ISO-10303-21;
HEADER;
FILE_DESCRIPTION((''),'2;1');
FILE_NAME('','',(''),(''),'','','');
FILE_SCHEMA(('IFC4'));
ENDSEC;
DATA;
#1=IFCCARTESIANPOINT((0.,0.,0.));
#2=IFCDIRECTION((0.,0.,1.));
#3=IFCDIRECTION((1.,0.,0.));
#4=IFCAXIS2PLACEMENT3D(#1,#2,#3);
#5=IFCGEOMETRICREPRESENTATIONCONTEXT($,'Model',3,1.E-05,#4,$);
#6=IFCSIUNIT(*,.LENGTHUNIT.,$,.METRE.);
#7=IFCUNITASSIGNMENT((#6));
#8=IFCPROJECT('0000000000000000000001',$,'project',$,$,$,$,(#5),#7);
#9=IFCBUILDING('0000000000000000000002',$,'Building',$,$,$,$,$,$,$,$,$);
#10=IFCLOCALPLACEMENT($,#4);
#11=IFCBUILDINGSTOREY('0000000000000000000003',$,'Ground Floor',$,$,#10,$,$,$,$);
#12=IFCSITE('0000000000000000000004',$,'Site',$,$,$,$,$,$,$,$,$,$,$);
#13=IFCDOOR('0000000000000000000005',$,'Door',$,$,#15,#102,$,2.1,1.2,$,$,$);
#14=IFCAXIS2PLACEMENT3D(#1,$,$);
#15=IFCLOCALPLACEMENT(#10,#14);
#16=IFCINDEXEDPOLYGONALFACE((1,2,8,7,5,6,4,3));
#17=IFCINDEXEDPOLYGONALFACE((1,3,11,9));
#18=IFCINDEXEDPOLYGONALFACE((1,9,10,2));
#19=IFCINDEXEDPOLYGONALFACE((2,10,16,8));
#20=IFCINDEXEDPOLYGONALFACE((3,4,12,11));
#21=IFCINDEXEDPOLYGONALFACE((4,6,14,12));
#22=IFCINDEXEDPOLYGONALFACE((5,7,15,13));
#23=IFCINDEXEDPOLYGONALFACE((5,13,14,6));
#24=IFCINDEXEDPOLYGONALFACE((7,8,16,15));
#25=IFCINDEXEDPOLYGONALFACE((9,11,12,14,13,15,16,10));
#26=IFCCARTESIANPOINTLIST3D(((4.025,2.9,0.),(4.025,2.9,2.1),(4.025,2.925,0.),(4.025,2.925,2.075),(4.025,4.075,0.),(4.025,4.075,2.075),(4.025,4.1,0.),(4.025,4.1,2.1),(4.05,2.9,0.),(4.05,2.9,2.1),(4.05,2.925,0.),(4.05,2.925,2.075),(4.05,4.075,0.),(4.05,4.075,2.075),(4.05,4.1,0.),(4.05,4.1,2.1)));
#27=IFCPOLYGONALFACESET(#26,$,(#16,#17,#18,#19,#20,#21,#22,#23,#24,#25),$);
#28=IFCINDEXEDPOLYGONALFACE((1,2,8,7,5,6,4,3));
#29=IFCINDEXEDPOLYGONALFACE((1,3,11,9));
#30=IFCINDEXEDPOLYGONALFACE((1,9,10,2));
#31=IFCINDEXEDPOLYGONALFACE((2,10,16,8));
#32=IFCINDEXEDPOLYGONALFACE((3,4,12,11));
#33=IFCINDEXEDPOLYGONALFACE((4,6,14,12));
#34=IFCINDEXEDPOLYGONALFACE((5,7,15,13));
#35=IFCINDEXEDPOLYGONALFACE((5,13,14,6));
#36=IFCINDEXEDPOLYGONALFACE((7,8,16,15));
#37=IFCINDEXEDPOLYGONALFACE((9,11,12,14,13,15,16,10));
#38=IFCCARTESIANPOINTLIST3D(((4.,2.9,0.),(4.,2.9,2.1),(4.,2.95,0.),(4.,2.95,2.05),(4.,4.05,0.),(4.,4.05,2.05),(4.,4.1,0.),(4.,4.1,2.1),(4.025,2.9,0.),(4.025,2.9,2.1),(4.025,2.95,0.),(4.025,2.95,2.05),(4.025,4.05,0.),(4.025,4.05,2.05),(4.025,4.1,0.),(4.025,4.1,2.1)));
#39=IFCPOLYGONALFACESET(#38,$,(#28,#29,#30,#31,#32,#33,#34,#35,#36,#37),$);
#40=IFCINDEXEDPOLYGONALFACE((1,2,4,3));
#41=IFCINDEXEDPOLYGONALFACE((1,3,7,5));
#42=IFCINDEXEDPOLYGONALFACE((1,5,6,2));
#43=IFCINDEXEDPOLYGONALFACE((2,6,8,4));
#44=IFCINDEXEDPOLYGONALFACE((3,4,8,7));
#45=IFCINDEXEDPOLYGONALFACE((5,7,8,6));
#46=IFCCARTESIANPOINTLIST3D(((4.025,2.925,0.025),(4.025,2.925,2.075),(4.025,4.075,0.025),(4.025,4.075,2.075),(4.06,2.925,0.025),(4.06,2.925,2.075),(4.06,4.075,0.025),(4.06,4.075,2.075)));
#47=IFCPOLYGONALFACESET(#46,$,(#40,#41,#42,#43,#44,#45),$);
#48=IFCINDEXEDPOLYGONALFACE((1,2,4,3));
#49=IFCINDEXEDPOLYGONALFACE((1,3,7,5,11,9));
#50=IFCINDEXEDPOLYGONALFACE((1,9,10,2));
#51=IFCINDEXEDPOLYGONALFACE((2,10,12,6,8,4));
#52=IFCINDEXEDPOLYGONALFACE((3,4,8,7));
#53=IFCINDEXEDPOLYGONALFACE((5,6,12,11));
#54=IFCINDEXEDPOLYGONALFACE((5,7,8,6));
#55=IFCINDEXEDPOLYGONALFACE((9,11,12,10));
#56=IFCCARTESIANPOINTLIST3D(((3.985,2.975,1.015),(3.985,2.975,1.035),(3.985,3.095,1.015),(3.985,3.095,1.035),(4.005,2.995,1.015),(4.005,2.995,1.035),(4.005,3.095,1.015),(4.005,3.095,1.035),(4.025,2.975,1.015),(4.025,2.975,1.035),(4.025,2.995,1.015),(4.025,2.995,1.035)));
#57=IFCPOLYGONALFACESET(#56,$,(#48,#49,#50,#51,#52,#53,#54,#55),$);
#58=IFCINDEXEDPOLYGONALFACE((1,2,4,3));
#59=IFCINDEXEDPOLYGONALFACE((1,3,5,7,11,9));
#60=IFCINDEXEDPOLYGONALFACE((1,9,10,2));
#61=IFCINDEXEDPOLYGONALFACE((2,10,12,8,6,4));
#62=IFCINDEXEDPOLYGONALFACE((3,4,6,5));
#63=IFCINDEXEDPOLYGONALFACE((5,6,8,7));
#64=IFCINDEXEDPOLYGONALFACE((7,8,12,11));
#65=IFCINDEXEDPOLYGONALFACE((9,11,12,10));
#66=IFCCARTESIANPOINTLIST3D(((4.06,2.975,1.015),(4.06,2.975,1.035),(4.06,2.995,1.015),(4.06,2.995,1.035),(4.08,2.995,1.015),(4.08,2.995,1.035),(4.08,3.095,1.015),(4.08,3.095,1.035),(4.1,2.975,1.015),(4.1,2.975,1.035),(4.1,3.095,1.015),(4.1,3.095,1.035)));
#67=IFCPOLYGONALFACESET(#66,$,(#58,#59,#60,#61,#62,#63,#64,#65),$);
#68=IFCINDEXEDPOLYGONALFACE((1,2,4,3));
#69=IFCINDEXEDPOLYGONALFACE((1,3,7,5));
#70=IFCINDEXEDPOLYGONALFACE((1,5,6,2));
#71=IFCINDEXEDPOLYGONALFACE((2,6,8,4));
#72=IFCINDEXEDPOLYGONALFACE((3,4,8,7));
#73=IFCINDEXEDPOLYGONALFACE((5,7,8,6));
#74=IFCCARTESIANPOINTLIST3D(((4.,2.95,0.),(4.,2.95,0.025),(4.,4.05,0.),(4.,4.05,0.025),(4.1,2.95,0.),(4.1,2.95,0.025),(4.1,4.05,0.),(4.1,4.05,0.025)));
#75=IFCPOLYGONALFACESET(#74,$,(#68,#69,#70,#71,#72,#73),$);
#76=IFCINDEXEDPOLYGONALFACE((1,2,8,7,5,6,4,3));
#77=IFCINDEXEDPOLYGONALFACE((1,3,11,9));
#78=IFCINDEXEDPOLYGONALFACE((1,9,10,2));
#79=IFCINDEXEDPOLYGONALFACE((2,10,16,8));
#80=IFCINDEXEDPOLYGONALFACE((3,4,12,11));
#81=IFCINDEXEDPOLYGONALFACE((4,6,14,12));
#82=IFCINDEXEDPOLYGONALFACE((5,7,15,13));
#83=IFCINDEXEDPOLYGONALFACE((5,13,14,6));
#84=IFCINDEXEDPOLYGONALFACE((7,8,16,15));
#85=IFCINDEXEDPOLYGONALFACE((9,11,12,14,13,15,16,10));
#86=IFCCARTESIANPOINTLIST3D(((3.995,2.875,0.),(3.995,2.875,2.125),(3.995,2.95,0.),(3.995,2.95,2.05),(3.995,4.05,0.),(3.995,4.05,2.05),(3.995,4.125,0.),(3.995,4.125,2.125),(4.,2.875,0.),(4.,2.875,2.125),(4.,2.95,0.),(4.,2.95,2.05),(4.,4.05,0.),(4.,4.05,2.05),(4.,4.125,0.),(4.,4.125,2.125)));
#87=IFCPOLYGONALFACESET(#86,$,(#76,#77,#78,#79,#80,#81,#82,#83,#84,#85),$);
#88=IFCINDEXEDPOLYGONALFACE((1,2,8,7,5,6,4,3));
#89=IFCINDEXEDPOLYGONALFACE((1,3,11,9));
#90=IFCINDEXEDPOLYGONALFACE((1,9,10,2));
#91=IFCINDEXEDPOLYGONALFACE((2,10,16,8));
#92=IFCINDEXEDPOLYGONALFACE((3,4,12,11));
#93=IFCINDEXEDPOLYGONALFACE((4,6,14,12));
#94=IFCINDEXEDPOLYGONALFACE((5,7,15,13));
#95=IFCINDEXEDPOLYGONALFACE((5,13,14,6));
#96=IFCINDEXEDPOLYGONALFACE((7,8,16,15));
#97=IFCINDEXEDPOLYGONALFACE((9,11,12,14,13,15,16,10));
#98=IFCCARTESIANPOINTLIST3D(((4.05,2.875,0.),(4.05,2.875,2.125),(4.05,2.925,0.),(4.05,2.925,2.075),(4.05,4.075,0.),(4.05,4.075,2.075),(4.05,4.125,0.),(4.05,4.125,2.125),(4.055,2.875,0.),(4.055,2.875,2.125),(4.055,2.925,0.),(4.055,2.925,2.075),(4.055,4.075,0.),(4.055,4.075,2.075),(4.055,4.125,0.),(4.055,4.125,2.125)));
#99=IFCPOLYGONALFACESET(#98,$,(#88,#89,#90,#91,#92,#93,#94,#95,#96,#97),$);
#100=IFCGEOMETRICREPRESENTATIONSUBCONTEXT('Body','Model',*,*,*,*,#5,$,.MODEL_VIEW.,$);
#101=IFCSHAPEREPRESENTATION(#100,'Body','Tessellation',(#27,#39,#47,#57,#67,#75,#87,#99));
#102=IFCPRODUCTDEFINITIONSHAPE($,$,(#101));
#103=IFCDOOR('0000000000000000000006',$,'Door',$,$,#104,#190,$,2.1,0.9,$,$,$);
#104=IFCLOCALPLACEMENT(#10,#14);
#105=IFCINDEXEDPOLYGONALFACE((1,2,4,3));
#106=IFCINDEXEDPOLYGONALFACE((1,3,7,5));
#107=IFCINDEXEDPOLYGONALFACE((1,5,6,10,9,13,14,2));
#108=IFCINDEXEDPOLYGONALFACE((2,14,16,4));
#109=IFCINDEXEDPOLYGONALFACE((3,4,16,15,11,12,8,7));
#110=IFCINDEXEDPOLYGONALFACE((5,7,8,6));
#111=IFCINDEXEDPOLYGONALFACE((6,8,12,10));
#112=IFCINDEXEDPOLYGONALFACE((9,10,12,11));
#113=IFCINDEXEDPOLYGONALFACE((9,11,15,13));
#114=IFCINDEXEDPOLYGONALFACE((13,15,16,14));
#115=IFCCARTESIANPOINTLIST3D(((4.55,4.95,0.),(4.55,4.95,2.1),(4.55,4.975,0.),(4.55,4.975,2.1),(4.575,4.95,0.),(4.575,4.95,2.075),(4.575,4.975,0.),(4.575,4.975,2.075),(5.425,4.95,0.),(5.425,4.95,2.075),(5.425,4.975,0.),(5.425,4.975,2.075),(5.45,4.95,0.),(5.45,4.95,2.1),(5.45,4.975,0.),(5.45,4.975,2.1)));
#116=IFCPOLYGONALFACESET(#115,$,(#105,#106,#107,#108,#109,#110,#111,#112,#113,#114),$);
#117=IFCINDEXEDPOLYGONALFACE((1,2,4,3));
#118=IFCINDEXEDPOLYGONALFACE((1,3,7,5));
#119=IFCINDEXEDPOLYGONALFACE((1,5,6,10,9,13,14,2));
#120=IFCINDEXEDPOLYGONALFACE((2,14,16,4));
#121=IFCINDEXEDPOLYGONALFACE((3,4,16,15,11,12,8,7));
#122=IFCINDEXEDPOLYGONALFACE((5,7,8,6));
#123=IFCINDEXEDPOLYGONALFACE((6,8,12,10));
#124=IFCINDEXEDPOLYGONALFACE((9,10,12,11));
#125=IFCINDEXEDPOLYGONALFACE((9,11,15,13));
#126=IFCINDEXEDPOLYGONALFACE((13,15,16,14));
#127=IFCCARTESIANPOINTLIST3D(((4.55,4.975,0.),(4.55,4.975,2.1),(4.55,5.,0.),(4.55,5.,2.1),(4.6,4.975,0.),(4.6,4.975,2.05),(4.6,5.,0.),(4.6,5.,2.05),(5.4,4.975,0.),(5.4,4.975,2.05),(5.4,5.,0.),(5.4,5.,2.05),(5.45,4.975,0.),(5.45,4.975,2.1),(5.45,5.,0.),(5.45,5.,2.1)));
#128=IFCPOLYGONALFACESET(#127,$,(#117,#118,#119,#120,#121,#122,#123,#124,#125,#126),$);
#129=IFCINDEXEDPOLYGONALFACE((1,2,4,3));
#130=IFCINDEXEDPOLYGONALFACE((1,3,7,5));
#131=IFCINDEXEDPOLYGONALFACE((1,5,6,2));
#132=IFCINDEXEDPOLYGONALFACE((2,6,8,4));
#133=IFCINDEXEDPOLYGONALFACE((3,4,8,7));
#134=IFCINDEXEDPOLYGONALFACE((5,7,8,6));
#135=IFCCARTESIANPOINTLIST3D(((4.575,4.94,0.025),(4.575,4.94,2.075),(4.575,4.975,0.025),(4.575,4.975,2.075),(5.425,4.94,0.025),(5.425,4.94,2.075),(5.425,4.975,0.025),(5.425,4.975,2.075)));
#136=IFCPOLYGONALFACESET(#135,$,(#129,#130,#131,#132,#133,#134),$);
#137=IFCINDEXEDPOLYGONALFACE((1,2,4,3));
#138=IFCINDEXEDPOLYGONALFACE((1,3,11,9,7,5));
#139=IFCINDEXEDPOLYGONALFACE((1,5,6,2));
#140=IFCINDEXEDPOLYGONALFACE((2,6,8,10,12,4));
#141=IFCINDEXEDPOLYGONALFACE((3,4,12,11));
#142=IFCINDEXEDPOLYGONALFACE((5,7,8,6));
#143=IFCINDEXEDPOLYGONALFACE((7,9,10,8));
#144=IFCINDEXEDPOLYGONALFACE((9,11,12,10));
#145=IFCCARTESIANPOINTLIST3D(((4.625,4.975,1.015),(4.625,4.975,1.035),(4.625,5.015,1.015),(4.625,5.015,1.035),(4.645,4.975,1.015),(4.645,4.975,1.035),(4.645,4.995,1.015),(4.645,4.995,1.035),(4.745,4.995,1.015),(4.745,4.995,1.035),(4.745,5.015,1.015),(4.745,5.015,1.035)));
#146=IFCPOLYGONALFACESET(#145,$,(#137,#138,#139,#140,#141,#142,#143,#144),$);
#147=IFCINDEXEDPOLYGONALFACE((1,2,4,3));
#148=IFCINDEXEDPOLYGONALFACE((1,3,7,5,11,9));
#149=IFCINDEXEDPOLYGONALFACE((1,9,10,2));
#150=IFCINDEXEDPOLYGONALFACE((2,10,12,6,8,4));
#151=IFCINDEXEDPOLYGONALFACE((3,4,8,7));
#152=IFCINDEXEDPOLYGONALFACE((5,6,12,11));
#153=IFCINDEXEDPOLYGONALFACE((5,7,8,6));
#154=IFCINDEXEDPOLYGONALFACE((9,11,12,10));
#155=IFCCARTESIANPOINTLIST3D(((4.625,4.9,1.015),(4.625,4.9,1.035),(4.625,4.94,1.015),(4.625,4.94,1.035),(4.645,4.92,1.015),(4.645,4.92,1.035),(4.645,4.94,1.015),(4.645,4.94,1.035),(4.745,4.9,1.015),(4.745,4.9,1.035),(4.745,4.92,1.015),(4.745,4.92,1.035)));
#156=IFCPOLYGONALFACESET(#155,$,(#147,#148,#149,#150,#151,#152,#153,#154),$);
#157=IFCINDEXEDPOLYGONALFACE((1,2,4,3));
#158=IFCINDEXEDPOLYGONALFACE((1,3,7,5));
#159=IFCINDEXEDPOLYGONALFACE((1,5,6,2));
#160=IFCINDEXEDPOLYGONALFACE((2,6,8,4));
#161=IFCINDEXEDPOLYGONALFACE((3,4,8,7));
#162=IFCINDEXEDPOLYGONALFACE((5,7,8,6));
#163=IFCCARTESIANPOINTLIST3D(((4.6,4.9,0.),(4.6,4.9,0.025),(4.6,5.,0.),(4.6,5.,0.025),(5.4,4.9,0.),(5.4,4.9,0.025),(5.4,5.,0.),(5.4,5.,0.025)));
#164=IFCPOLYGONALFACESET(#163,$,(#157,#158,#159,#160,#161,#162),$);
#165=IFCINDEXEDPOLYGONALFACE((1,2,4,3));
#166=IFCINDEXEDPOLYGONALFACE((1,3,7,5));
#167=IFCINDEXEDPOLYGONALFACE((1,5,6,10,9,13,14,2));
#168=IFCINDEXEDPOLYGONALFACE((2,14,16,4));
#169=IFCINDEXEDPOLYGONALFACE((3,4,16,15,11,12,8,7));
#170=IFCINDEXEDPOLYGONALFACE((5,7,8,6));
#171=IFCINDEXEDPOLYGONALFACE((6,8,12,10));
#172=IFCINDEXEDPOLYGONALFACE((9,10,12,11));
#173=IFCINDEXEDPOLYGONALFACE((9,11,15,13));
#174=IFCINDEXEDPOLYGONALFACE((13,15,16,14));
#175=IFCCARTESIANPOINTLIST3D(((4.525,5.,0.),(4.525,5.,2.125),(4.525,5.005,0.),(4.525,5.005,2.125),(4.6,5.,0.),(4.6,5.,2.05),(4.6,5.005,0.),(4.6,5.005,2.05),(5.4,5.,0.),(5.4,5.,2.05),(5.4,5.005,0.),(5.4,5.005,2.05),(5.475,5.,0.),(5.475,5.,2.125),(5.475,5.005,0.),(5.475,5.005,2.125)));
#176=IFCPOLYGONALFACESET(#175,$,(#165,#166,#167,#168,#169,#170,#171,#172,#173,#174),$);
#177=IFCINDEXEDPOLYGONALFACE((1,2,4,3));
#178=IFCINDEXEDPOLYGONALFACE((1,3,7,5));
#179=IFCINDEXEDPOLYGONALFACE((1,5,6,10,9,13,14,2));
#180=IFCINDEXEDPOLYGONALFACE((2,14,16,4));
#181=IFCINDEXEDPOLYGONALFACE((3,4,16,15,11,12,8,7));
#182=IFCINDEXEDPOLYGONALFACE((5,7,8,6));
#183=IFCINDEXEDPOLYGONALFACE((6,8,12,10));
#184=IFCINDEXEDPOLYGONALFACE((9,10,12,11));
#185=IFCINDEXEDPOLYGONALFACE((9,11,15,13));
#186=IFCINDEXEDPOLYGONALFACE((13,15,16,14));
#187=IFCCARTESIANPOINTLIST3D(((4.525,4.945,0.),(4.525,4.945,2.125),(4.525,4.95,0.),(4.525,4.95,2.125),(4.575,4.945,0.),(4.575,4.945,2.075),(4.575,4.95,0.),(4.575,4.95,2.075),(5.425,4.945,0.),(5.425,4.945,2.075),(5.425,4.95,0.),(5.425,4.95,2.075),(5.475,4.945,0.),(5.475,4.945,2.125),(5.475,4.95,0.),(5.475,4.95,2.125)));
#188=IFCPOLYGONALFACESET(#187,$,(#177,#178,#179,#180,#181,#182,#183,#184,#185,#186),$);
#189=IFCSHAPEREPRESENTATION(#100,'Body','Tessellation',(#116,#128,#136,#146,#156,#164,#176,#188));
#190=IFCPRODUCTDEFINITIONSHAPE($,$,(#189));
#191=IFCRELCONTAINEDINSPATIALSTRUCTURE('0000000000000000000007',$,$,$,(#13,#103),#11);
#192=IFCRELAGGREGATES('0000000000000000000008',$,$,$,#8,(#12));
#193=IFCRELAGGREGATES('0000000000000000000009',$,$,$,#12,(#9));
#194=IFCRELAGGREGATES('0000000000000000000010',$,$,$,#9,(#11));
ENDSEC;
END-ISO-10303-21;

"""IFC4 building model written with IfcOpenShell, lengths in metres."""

from ifc_helpers import new_model, si_unit, frame, origin_with_axes, place, context, subcontext, project, spatial, line, indexed_curve, outline, extrude, element, save


model = new_model("IFC4")

# Units and contexts
model_context = context("Model", 3, precision=1e-05, world=origin_with_axes())
body_context = subcontext(model_context, "Body", "Model", "MODEL_VIEW")
ifc_project = project(units=[si_unit("LENGTHUNIT", "METRE")], contexts=[model_context])

# Site, building, storey
site = spatial("IfcSite", under=ifc_project, Name="Site")
building = spatial("IfcBuilding", under=site, Name="Building")
storey_placement = place(None, origin_with_axes())
storey = spatial("IfcBuildingStorey", under=building, at=storey_placement, Name="Ground Floor")

# Doors
door_1_placement = place(storey_placement, frame((4.0, 4.1, 0.0), z_axis=(0.0, 0.0, 1.0), x_axis=(0.0, -1.0, 0.0)))
element("IfcDoor", 1, at=door_1_placement, inside=storey, Name="Door", OverallHeight=2.1, OverallWidth=1.2, context=body_context, shape_type="SweptSolid", body=[
    extrude(outline(indexed_curve([(0.0, 0.0), (0.0, 2.1), (1.2, 2.1), (1.2, 0.0), (1.175, 0.0), (1.175, 2.075), (0.025, 2.075), (0.025, 0.0)], segments=[line(1, 2, 3, 4, 5, 6, 7, 8, 1)])), frame((0.0, 0.025, 0.0), z_axis=(0.0, -1.0, 0.0), x_axis=(1.0, 0.0, 0.0)), (0.0, 0.0, -1.0), 0.025),
    extrude(outline(indexed_curve([(0.0, 0.0), (0.0, 2.1), (1.2, 2.1), (1.2, 0.0), (1.15, 0.0), (1.15, 2.05), (0.05, 2.05), (0.05, 0.0)], segments=[line(1, 2, 3, 4, 5, 6, 7, 8, 1)])), frame((0.0, 0.0, 0.0), z_axis=(0.0, -1.0, 0.0), x_axis=(1.0, 0.0, 0.0)), (0.0, 0.0, -1.0), 0.025),
    extrude(outline(indexed_curve([(0.0, 0.0), (1.15, 0.0), (1.15, 0.035), (0.0, 0.035)], segments=[line(1, 2, 3, 4, 1)])), frame((0.025, 0.025, 0.025), z_axis=(0.0, 0.0, 1.0), x_axis=(1.0, 0.0, 0.0)), (0.0, 0.0, 1.0), 2.05),
    extrude(outline(indexed_curve([(0.0, 0.0), (0.0, -0.04), (-0.12, -0.04), (-0.12, -0.02), (-0.02, -0.02), (-0.02, 0.0)], segments=[line(1, 2, 3, 4, 5, 6, 1)])), frame((1.125, 0.025, 1.015), z_axis=(0.0, 0.0, 1.0), x_axis=(1.0, 0.0, 0.0)), (0.0, 0.0, 1.0), 0.02),
    extrude(outline(indexed_curve([(0.0, 0.0), (0.0, 0.04), (-0.12, 0.04), (-0.12, 0.02), (-0.02, 0.02), (-0.02, 0.0)], segments=[line(1, 2, 3, 4, 5, 6, 1)])), frame((1.125, 0.06, 1.015), z_axis=(0.0, 0.0, 1.0), x_axis=(1.0, 0.0, 0.0)), (0.0, 0.0, 1.0), 0.02),
    extrude(outline(indexed_curve([(0.0, 0.0), (1.1, 0.0), (1.1, 0.1), (0.0, 0.1)], segments=[line(1, 2, 3, 4, 1)])), frame((0.05, 0.0, 0.0), z_axis=(0.0, 0.0, 1.0), x_axis=(1.0, 0.0, 0.0)), (0.0, 0.0, 1.0), 0.025),
    extrude(outline(indexed_curve([(0.0, 0.0), (0.0, 2.125), (1.25, 2.125), (1.25, 0.0), (1.175, 0.0), (1.175, 2.05), (0.075, 2.05), (0.075, 0.0)], segments=[line(1, 2, 3, 4, 5, 6, 7, 8, 1)])), frame((-0.025, -0.005, 0.0), z_axis=(0.0, -1.0, 0.0), x_axis=(1.0, 0.0, 0.0)), (0.0, 0.0, -1.0), 0.005),
    extrude(outline(indexed_curve([(0.0, 0.0), (0.0, 2.125), (1.25, 2.125), (1.25, 0.0), (1.2, 0.0), (1.2, 2.075), (0.05, 2.075), (0.05, 0.0)], segments=[line(1, 2, 3, 4, 5, 6, 7, 8, 1)])), frame((-0.025, 0.05, 0.0), z_axis=(0.0, -1.0, 0.0), x_axis=(1.0, 0.0, 0.0)), (0.0, 0.0, -1.0), 0.005),
])
door_2_placement = place(storey_placement, frame((5.45, 5.0, 0.0), z_axis=(0.0, 0.0, 1.0), x_axis=(-1.0, 0.0, 0.0)))
element("IfcDoor", 2, at=door_2_placement, inside=storey, Name="Door", OverallHeight=2.1, OverallWidth=0.9, context=body_context, shape_type="SweptSolid", body=[
    extrude(outline(indexed_curve([(0.0, 0.0), (0.0, 2.1), (0.9, 2.1), (0.9, 0.0), (0.875, 0.0), (0.875, 2.075), (0.025, 2.075), (0.025, 0.0)], segments=[line(1, 2, 3, 4, 5, 6, 7, 8, 1)])), frame((0.0, 0.025, 0.0), z_axis=(0.0, -1.0, 0.0), x_axis=(1.0, 0.0, 0.0)), (0.0, 0.0, -1.0), 0.025),
    extrude(outline(indexed_curve([(0.0, 0.0), (0.0, 2.1), (0.9, 2.1), (0.9, 0.0), (0.85, 0.0), (0.85, 2.05), (0.05, 2.05), (0.05, 0.0)], segments=[line(1, 2, 3, 4, 5, 6, 7, 8, 1)])), frame((0.0, 0.0, 0.0), z_axis=(0.0, -1.0, 0.0), x_axis=(1.0, 0.0, 0.0)), (0.0, 0.0, -1.0), 0.025),
    extrude(outline(indexed_curve([(0.0, 0.0), (0.85, 0.0), (0.85, 0.035), (0.0, 0.035)], segments=[line(1, 2, 3, 4, 1)])), frame((0.025, 0.025, 0.025), z_axis=(0.0, 0.0, 1.0), x_axis=(1.0, 0.0, 0.0)), (0.0, 0.0, 1.0), 2.05),
    extrude(outline(indexed_curve([(0.0, 0.0), (0.0, -0.04), (-0.12, -0.04), (-0.12, -0.02), (-0.02, -0.02), (-0.02, 0.0)], segments=[line(1, 2, 3, 4, 5, 6, 1)])), frame((0.825, 0.025, 1.015), z_axis=(0.0, 0.0, 1.0), x_axis=(1.0, 0.0, 0.0)), (0.0, 0.0, 1.0), 0.02),
    extrude(outline(indexed_curve([(0.0, 0.0), (0.0, 0.04), (-0.12, 0.04), (-0.12, 0.02), (-0.02, 0.02), (-0.02, 0.0)], segments=[line(1, 2, 3, 4, 5, 6, 1)])), frame((0.825, 0.06, 1.015), z_axis=(0.0, 0.0, 1.0), x_axis=(1.0, 0.0, 0.0)), (0.0, 0.0, 1.0), 0.02),
    extrude(outline(indexed_curve([(0.0, 0.0), (0.8, 0.0), (0.8, 0.1), (0.0, 0.1)], segments=[line(1, 2, 3, 4, 1)])), frame((0.05, 0.0, 0.0), z_axis=(0.0, 0.0, 1.0), x_axis=(1.0, 0.0, 0.0)), (0.0, 0.0, 1.0), 0.025),
    extrude(outline(indexed_curve([(0.0, 0.0), (0.0, 2.125), (0.95, 2.125), (0.95, 0.0), (0.875, 0.0), (0.875, 2.05), (0.075, 2.05), (0.075, 0.0)], segments=[line(1, 2, 3, 4, 5, 6, 7, 8, 1)])), frame((-0.025, -0.005, 0.0), z_axis=(0.0, -1.0, 0.0), x_axis=(1.0, 0.0, 0.0)), (0.0, 0.0, -1.0), 0.005),
    extrude(outline(indexed_curve([(0.0, 0.0), (0.0, 2.125), (0.95, 2.125), (0.95, 0.0), (0.9, 0.0), (0.9, 2.075), (0.05, 2.075), (0.05, 0.0)], segments=[line(1, 2, 3, 4, 5, 6, 7, 8, 1)])), frame((-0.025, 0.05, 0.0), z_axis=(0.0, -1.0, 0.0), x_axis=(1.0, 0.0, 0.0)), (0.0, 0.0, -1.0), 0.005),
])

save(model, "model.ifc")
